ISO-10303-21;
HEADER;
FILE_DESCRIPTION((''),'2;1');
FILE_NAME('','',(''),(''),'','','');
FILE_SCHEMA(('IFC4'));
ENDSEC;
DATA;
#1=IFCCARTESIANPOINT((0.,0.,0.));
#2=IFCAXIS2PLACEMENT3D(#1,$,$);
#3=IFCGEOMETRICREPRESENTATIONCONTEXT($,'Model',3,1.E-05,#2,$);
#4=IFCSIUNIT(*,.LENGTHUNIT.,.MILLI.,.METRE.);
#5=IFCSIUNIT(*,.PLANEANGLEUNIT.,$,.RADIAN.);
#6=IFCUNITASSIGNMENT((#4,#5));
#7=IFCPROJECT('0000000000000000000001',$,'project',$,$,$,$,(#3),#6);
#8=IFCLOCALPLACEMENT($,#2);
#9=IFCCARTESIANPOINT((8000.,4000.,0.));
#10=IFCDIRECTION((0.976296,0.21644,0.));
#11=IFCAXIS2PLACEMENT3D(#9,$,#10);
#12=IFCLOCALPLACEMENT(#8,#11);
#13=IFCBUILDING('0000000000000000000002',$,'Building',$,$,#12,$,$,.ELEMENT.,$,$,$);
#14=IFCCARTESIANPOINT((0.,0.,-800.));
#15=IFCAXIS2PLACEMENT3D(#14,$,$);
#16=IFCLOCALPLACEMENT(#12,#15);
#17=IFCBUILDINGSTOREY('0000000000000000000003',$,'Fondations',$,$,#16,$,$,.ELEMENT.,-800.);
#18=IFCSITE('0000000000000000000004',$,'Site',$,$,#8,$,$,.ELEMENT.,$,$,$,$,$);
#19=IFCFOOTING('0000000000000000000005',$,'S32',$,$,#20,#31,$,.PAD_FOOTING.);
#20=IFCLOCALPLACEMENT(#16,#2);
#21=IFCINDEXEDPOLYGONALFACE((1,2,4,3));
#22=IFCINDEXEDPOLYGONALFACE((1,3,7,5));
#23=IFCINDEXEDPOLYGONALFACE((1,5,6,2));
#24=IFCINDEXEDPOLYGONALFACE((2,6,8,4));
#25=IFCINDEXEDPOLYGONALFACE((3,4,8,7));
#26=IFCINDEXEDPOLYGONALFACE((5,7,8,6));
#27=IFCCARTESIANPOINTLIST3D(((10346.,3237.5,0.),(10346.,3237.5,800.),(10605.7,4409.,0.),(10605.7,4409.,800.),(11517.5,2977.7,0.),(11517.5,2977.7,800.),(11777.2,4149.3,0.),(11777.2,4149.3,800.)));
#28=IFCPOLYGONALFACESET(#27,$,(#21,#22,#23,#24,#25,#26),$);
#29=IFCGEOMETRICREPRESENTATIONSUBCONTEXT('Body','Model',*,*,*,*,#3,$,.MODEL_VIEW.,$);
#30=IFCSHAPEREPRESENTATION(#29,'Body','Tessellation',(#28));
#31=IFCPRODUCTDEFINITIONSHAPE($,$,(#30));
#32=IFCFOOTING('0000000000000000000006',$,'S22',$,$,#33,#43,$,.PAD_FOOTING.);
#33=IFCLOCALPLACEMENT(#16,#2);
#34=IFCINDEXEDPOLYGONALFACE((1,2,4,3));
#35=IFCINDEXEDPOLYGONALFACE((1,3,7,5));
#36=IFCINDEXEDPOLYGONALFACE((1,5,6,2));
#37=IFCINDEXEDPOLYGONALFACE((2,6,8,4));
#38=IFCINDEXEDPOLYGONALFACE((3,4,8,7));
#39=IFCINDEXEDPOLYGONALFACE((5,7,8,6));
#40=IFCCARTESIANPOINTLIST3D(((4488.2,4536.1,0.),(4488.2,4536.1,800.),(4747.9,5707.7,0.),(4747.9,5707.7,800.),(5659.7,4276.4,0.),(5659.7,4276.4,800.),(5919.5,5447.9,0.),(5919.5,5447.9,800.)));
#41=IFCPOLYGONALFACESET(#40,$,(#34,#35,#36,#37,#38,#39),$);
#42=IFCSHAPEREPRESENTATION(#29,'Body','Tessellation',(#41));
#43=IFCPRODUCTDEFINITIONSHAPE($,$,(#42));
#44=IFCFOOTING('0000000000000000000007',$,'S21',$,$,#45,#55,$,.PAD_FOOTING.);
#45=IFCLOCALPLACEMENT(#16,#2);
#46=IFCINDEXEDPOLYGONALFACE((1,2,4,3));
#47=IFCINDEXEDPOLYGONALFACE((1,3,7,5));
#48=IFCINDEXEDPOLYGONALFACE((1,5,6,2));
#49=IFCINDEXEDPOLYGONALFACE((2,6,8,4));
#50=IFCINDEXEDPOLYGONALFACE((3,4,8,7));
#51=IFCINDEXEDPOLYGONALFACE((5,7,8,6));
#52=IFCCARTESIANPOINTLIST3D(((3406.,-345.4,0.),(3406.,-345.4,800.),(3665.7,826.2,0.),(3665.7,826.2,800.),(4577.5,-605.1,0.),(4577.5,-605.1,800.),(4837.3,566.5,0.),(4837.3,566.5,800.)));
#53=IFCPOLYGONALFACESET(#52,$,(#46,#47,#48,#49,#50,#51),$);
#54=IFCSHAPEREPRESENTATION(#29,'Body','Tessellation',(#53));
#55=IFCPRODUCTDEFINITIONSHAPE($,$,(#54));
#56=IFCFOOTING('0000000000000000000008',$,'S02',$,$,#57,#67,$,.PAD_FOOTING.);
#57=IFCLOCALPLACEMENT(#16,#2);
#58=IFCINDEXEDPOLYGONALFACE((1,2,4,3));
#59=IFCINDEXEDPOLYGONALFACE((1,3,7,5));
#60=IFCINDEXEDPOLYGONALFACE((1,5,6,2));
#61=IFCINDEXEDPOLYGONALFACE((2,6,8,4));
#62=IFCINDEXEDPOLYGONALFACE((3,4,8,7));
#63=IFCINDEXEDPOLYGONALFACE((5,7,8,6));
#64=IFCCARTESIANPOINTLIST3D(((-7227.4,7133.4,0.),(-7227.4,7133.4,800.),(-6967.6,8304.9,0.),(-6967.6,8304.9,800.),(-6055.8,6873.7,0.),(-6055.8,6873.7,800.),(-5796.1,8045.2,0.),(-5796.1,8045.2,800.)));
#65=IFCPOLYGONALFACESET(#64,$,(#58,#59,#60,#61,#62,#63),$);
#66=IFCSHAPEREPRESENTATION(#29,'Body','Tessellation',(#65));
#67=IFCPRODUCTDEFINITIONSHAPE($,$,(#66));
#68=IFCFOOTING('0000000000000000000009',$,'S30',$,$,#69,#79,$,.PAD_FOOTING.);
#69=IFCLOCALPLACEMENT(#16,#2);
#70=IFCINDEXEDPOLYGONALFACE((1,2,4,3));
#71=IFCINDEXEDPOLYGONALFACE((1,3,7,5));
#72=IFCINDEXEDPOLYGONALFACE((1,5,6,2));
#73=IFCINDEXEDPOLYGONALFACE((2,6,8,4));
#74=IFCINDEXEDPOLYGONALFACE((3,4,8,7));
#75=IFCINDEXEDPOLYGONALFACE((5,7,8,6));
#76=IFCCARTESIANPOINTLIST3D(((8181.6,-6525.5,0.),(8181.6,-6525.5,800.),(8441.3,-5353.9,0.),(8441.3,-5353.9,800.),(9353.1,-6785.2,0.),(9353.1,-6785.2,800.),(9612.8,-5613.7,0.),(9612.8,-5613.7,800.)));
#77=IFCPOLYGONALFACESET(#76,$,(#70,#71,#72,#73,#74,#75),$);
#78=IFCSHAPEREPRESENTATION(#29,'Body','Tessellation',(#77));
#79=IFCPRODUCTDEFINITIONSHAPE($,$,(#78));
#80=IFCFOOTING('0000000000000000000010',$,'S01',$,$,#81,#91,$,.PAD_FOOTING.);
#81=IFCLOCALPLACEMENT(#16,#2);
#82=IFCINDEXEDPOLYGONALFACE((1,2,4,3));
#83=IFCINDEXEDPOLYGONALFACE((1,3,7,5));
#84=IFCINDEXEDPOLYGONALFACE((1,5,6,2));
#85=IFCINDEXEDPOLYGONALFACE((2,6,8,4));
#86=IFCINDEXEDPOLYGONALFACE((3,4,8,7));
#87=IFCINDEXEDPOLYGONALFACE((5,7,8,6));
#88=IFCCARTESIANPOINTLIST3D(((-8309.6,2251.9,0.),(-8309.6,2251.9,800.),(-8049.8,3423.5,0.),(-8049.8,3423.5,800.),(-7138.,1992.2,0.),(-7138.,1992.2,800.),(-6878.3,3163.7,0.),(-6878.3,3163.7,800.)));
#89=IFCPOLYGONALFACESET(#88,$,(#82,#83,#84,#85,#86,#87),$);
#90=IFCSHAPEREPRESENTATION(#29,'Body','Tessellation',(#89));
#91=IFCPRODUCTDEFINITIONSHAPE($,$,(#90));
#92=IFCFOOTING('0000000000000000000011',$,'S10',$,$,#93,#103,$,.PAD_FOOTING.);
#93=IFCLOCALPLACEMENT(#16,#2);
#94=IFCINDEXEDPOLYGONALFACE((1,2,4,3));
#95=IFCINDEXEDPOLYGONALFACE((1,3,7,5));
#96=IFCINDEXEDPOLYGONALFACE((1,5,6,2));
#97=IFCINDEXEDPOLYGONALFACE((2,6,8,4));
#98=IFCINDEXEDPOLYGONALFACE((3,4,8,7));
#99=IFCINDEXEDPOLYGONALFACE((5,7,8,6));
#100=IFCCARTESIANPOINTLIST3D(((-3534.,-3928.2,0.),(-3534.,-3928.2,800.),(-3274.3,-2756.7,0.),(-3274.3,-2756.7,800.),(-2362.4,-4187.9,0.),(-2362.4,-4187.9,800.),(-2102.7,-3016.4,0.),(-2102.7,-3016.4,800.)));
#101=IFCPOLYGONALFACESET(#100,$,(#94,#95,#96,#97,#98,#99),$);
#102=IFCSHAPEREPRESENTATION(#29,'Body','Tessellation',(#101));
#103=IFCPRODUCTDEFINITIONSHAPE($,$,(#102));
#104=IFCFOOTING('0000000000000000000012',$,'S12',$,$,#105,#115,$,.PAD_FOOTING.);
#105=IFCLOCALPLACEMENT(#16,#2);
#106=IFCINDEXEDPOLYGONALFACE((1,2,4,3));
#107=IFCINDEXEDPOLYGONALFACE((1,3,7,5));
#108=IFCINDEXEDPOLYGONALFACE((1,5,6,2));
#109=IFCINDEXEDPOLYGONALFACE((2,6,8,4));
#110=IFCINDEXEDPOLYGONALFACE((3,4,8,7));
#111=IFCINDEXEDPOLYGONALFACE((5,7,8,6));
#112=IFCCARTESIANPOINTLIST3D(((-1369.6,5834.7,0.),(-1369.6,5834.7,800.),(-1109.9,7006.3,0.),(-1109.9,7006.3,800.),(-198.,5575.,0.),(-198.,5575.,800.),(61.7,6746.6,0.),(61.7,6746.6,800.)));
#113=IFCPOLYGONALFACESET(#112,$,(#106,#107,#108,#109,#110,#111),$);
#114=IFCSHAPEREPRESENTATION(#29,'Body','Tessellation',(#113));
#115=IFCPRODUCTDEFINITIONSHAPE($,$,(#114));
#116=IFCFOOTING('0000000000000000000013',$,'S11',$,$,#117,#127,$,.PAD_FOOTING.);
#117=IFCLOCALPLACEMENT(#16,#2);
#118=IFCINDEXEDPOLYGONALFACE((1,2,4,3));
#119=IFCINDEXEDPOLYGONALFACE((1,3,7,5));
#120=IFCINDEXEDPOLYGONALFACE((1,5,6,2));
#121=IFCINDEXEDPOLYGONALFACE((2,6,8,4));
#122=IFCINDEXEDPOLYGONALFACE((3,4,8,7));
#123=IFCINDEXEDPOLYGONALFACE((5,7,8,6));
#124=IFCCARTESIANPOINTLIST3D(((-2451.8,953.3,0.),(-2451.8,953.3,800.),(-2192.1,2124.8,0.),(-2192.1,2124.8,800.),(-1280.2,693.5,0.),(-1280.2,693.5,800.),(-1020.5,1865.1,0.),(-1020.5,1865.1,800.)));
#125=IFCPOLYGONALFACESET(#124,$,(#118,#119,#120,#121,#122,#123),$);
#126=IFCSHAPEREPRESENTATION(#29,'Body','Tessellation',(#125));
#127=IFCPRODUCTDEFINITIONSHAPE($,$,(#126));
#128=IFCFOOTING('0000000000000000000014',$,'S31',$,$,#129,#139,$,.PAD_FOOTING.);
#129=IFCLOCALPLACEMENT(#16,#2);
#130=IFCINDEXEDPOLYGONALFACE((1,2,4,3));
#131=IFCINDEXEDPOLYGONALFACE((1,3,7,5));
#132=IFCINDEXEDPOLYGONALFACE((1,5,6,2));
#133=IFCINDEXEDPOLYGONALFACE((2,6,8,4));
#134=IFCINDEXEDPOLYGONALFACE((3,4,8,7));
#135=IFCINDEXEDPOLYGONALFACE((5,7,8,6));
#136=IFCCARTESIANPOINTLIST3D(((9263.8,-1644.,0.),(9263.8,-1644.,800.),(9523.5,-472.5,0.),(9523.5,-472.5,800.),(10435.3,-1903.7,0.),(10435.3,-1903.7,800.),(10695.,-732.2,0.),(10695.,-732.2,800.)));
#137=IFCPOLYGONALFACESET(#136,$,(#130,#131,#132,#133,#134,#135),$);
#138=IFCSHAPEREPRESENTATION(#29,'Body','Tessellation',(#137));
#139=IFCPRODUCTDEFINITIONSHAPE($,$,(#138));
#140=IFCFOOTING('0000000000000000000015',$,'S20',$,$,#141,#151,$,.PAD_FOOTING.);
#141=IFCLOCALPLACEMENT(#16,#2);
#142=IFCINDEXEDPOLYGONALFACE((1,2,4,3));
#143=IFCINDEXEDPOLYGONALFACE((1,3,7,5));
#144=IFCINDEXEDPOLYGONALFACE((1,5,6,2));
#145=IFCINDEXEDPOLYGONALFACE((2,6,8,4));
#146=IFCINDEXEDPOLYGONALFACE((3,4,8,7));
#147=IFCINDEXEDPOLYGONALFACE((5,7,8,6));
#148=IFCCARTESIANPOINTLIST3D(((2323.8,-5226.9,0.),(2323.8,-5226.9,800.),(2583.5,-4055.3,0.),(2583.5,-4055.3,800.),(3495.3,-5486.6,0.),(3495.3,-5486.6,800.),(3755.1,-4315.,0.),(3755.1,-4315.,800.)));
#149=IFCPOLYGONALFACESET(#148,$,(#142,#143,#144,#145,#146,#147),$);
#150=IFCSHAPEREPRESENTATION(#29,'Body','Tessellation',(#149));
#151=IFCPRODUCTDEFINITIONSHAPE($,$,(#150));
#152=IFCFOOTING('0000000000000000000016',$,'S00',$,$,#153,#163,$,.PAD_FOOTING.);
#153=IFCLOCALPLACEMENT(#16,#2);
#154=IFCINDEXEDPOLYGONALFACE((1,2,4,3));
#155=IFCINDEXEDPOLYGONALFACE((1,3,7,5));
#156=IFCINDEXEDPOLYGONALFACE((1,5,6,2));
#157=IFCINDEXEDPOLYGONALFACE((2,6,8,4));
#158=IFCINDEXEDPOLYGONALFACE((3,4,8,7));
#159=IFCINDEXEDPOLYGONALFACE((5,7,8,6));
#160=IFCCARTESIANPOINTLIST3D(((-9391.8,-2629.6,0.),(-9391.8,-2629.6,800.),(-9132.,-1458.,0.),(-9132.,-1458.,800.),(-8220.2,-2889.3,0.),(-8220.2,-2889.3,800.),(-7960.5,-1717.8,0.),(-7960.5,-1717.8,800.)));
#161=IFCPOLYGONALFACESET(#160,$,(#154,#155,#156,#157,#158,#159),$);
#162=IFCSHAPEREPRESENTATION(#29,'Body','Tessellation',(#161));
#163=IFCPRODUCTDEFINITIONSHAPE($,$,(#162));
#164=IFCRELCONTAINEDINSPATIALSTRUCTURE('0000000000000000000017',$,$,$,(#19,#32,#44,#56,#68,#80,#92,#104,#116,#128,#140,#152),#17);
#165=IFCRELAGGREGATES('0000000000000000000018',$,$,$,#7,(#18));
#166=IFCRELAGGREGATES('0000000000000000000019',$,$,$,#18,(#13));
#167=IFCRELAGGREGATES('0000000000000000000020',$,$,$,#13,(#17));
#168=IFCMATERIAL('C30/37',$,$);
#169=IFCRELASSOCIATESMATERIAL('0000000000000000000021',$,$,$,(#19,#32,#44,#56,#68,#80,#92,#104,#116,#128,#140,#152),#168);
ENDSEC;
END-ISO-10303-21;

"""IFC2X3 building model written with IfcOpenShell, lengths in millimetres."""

from ifc_helpers import new_model, si_unit, frame, origin, origin_2d, place, context, subcontext, project, spatial, rectangle, extrude, material, element, save


model = new_model("IFC2X3")

# Units and contexts
model_context = context("Model", 3, precision=1e-05, world=origin())
body_context = subcontext(model_context, "Body", "Model", "MODEL_VIEW")
ifc_project = project(units=[si_unit("LENGTHUNIT", "METRE", prefix="MILLI"), si_unit("PLANEANGLEUNIT", "RADIAN")], contexts=[model_context])

# Site, building, storey
site_placement = place(None, origin())
site = spatial("IfcSite", under=ifc_project, at=site_placement, Name="Site", CompositionType="ELEMENT")
building_placement = place(site_placement, frame((8000.0, 4000.0, 0.0), x_axis=(0.976296, 0.21644, 0.0)))
building = spatial("IfcBuilding", under=site, at=building_placement, Name="Building", CompositionType="ELEMENT")
storey_placement = place(building_placement, frame((0.0, 0.0, -800.0)))
storey = spatial("IfcBuildingStorey", under=building, at=storey_placement, Name="Fondations", CompositionType="ELEMENT", Elevation=-800.0)

# Footings
ifc_material = material(Name="C30/37")
for number, where, z_axis, x_axis, name in (
    (1, (11061.6, 3693.4, 0.0), (0.0, 0.0, 1.0), (0.976296, -0.21644, 0.0), "S32"),
    (2, (5203.8, 4992.0, 0.0), (0.0, 0.0, 1.0), (0.976296, -0.21644, 0.0), "S22"),
    (3, (4121.6, 110.5, 0.0), (0.0, 0.0, 1.0), (0.976296, -0.21644, 0.0), "S21"),
    (4, (-6511.7, 7589.3, 0.0), (0.0, 0.0, 1.0), (0.976296, -0.21644, 0.0), "S02"),
    (5, (8897.2, -6069.6, 0.0), (0.0, 0.0, 1.0), (0.976296, -0.21644, 0.0), "S30"),
    (6, (-7593.9, 2707.8, 0.0), (0.0, 0.0, 1.0), (0.976296, -0.21644, 0.0), "S01"),
    (7, (-2818.4, -3472.3, 0.0), (0.0, 0.0, 1.0), (0.976296, -0.21644, 0.0), "S10"),
    (8, (-654.0, 6290.7, 0.0), (0.0, 0.0, 1.0), (0.976296, -0.21644, 0.0), "S12"),
    (9, (-1736.2, 1409.2, 0.0), (0.0, 0.0, 1.0), (0.976296, -0.21644, 0.0), "S11"),
    (10, (9979.4, -1188.1, 0.0), (0.0, 0.0, 1.0), (0.976296, -0.21644, 0.0), "S31"),
    (11, (3039.4, -4770.9, 0.0), (0.0, 0.0, 1.0), (0.976296, -0.21644, 0.0), "S20"),
    (12, (-8676.1, -2173.7, 0.0), (0.0, 0.0, 1.0), (0.976296, -0.21644, 0.0), "S00"),
):
    element("IfcFooting", number, at=place(storey_placement, frame(where, z_axis=z_axis, x_axis=x_axis)), inside=storey, material=ifc_material, Name=name, PredefinedType="PAD_FOOTING", context=body_context, shape_type="SweptSolid", body=[
        extrude(rectangle(XDim=1200.0, YDim=1200.0, at=origin_2d()), origin(), (0.0, 0.0, 1.0), 800.0),
    ])

save(model, "model.ifc")
